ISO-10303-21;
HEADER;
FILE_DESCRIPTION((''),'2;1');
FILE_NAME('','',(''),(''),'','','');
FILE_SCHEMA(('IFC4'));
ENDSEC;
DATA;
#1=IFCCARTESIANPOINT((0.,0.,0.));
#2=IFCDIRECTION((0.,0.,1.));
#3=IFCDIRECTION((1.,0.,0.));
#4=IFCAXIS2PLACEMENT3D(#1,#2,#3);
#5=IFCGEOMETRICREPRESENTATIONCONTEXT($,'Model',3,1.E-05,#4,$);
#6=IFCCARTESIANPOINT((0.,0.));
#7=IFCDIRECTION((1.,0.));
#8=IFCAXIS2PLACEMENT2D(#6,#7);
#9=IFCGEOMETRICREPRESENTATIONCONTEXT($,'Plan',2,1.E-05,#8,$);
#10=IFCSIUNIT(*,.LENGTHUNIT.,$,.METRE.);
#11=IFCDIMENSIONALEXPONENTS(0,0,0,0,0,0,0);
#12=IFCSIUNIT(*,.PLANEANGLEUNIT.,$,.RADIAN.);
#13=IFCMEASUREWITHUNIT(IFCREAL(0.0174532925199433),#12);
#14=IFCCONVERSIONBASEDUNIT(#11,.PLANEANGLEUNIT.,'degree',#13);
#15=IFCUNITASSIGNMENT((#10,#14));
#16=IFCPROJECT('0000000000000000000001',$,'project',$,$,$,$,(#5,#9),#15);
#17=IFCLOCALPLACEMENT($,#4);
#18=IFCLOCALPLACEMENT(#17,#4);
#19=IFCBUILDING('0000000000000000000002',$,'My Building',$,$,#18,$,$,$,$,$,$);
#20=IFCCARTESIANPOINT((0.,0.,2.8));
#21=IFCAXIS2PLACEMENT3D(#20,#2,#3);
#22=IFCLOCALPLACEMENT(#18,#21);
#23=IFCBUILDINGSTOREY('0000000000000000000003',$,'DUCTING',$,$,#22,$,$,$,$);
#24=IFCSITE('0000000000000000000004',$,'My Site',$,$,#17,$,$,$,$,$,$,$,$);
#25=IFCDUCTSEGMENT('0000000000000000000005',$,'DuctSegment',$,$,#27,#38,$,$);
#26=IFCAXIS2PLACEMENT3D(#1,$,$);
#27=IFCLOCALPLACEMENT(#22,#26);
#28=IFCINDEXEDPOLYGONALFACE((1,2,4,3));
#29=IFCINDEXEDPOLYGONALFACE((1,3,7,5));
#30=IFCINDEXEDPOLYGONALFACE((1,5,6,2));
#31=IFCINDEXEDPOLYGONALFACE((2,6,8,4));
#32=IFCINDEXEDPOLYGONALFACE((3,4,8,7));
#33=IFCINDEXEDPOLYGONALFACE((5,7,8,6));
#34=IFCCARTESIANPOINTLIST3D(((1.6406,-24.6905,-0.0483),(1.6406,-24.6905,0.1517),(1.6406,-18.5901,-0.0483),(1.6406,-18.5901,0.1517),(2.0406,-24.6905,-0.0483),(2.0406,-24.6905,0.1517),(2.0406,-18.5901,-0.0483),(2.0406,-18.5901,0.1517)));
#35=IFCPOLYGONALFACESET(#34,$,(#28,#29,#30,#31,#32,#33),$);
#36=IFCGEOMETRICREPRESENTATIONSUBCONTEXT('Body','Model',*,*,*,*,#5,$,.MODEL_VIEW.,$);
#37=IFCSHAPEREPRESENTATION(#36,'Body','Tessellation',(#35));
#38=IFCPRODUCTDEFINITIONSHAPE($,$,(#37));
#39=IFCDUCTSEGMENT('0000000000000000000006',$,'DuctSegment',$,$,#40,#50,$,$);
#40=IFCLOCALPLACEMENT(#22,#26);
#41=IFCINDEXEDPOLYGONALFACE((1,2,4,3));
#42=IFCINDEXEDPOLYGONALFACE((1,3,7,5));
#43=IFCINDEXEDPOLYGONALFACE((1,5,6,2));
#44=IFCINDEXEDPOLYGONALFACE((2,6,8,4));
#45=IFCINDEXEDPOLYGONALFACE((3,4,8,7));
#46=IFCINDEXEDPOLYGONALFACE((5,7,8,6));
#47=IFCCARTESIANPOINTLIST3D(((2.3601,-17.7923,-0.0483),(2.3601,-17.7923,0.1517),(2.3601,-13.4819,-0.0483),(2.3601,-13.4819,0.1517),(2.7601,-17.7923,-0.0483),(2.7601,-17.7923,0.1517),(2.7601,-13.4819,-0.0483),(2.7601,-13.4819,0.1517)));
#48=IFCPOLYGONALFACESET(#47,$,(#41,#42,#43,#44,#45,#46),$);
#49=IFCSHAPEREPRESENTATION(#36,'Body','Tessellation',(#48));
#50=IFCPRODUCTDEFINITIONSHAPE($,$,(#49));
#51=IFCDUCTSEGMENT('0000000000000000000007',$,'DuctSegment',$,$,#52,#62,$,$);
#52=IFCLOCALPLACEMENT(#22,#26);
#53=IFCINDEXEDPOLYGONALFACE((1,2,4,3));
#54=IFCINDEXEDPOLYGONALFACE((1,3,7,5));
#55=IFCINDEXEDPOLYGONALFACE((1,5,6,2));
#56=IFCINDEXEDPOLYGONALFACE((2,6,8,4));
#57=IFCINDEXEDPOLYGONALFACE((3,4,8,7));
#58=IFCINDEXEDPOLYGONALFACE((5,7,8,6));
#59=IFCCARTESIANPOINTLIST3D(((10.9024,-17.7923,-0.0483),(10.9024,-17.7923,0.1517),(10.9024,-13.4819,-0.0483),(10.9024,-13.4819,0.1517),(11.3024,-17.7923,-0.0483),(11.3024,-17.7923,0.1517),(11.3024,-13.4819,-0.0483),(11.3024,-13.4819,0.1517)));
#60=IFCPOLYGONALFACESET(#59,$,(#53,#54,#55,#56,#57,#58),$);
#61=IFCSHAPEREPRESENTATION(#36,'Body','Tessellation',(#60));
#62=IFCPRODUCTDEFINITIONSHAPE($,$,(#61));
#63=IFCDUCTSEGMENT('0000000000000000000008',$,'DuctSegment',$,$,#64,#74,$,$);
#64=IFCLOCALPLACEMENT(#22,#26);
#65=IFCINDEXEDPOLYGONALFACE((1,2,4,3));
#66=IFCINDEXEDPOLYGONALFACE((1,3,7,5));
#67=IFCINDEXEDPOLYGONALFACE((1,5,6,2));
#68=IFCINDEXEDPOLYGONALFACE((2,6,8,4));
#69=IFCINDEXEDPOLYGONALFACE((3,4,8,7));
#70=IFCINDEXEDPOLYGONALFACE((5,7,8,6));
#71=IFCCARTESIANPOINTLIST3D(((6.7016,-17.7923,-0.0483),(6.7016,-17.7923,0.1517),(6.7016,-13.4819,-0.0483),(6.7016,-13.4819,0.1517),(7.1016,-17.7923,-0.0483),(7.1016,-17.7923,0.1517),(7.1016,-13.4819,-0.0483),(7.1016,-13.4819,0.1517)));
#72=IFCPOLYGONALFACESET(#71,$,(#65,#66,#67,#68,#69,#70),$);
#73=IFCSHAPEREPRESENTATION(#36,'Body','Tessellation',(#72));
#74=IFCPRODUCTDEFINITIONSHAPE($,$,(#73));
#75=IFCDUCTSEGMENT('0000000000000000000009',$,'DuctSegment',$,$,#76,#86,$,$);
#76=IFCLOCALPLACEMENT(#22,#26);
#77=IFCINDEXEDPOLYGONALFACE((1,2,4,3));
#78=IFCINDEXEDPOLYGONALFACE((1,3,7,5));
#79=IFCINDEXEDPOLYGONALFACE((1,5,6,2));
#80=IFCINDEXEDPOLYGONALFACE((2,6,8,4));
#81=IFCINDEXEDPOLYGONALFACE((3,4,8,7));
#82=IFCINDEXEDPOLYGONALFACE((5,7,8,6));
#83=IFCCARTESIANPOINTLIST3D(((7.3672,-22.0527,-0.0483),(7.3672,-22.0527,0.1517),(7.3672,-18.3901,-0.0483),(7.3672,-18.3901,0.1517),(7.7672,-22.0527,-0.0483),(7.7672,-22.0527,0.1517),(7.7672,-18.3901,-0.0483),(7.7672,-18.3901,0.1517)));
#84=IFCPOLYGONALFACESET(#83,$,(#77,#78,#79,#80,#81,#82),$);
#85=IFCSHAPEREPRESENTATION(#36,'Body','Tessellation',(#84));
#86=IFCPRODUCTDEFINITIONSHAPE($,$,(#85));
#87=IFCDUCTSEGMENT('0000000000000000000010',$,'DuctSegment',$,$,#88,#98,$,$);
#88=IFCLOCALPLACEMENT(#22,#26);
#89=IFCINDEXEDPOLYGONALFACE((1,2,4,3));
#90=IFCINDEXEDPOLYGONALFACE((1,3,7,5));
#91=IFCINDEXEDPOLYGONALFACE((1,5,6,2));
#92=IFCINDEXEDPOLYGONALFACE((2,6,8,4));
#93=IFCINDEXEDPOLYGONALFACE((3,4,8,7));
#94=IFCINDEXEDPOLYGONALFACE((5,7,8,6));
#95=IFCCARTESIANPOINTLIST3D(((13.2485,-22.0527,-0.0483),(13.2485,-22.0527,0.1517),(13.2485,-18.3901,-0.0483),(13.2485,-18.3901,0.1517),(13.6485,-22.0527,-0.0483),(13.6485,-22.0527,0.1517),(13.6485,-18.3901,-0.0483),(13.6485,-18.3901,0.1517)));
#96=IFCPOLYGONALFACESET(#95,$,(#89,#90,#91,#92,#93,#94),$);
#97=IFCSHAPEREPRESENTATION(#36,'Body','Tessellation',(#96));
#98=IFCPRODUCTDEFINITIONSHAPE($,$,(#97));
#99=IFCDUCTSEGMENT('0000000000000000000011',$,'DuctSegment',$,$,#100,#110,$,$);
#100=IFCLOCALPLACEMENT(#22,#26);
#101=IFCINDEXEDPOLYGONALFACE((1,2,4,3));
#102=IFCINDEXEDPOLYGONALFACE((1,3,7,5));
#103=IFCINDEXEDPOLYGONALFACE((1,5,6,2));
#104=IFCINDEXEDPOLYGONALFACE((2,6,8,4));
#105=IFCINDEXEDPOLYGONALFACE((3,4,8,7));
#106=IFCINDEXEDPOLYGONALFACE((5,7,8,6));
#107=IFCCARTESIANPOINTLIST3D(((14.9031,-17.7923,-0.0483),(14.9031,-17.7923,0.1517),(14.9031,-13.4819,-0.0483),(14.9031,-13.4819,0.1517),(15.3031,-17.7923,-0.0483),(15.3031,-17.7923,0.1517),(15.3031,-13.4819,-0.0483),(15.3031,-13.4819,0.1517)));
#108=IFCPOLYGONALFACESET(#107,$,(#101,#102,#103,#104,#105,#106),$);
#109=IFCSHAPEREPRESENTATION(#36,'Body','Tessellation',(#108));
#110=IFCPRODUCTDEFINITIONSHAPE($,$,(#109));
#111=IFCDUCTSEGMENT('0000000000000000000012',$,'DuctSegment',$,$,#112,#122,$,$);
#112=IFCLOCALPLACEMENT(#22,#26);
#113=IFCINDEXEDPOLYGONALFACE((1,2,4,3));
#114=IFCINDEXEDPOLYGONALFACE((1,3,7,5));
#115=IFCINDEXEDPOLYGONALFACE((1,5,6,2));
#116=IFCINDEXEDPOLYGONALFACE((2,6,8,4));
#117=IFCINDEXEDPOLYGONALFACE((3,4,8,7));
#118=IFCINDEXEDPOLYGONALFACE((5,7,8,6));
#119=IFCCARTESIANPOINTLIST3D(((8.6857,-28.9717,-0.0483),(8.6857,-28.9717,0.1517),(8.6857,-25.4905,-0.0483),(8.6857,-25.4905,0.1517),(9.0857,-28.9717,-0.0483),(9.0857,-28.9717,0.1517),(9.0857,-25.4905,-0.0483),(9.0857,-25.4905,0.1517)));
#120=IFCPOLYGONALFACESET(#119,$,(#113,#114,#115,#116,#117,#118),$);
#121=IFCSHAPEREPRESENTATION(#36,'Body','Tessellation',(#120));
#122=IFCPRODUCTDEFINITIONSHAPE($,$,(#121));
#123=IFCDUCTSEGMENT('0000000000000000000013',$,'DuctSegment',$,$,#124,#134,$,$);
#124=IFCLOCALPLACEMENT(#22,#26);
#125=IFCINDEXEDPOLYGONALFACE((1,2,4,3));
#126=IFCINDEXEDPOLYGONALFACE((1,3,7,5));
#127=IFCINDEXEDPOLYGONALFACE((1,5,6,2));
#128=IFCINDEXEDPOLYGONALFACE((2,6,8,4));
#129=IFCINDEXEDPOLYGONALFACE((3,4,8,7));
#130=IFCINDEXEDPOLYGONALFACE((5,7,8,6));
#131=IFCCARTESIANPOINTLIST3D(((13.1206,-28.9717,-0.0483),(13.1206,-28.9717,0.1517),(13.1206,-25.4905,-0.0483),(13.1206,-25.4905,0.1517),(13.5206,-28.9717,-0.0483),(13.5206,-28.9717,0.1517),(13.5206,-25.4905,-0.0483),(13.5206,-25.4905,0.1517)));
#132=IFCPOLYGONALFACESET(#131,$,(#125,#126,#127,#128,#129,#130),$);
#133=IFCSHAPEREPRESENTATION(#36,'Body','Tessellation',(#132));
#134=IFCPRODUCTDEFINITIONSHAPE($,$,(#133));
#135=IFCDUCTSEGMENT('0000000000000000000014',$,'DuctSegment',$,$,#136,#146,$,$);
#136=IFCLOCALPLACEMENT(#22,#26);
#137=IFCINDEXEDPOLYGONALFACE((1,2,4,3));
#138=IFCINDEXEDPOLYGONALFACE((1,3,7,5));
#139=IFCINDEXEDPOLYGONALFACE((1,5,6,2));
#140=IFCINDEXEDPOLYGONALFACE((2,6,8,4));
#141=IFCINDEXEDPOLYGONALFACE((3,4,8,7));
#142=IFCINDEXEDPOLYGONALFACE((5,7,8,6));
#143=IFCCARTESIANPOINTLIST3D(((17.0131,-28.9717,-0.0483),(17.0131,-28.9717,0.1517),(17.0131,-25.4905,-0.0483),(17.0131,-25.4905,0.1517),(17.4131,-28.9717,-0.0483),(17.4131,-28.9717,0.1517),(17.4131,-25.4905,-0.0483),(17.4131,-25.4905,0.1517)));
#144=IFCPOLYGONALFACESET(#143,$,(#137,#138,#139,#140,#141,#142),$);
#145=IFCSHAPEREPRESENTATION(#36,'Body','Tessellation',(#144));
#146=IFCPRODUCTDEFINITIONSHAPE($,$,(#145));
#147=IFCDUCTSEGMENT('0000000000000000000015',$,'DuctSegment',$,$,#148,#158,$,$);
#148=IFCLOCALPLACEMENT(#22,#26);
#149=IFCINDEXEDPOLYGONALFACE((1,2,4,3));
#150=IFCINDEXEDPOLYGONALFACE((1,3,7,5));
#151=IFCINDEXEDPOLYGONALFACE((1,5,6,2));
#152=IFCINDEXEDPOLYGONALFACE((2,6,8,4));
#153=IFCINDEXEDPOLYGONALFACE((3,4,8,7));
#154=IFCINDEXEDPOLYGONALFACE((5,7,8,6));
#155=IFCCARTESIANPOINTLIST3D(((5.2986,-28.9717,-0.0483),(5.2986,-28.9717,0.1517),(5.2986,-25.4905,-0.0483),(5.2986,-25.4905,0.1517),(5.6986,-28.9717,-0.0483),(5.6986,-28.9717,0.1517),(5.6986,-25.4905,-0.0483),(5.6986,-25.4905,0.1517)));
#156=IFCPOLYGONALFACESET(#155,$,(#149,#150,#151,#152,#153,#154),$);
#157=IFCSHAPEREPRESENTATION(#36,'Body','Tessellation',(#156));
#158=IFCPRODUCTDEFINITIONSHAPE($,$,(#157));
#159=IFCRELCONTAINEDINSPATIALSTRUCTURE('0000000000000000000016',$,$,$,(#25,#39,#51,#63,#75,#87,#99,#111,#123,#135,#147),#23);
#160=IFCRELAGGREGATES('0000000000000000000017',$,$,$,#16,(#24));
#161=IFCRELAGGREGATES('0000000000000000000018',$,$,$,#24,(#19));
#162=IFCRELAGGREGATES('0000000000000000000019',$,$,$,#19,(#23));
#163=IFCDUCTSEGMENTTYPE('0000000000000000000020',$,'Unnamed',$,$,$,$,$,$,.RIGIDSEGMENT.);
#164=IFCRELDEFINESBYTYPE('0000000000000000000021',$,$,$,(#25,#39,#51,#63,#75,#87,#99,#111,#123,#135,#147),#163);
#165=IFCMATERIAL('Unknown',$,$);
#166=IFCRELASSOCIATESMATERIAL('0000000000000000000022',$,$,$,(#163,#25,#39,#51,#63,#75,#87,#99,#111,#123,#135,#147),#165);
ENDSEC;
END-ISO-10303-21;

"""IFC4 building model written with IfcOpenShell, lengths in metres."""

from ifc_helpers import new_model, entity, si_unit, converted_unit, frame, origin_with_axes, origin_2d_with_axis, place, context, subcontext, project, spatial, rectangle, extrude, material, material_profile, profile_set, profile_usage, type_object, element, save


model = new_model("IFC4")

# Units and contexts
model_context = context("Model", 3, precision=1e-05, world=origin_with_axes())
plan_context = context("Plan", 2, precision=1e-05, world=origin_2d_with_axis())
body_context = subcontext(model_context, "Body", "Model", "MODEL_VIEW")
ifc_project = project(units=[si_unit("LENGTHUNIT", "METRE"), converted_unit("PLANEANGLEUNIT", "degree", entity("IfcReal", 0.0174532925199433), si_unit("PLANEANGLEUNIT", "RADIAN"), dimensions=[0, 0, 0, 0, 0, 0, 0])], contexts=[model_context, plan_context])

# Site, building, storey
site_placement = place(None, origin_with_axes())
site = spatial("IfcSite", under=ifc_project, at=site_placement, Name="My Site")
building_placement = place(site_placement, origin_with_axes())
building = spatial("IfcBuilding", under=site, at=building_placement, Name="My Building")
storey_placement = place(building_placement, frame((0.0, 0.0, 2.8), z_axis=(0.0, 0.0, 1.0), x_axis=(1.0, 0.0, 0.0)))
storey = spatial("IfcBuildingStorey", under=building, at=storey_placement, Name="DUCTING")

# Duct segments
ifc_material = material(Name="Unknown")
ifc_material_profile_1 = material_profile(ifc_material, rectangle(XDim=0.4, YDim=0.2))
ifc_profile_set_1 = profile_set([ifc_material_profile_1])
ifc_profile_usage_1 = profile_usage(ifc_profile_set_1, cardinal=5)
duct_segment_type = type_object("IfcDuctSegmentType", Name="Unnamed", PredefinedType="RIGIDSEGMENT", material=ifc_profile_set_1)
duct_segment_1_placement = place(storey_placement, frame((1.8406, -18.5901, 0.0517), z_axis=(0.0, -1.0, 0.0), x_axis=(1.0, 0.0, 0.0)))
element("IfcDuctSegment", 1, at=duct_segment_1_placement, inside=storey, type_object=duct_segment_type, material=ifc_profile_usage_1, Name="DuctSegment", context=body_context, shape_type="SweptSolid", body=[
    extrude(rectangle(XDim=0.4, YDim=0.2), origin_with_axes(), (0.0, 0.0, 1.0), 6.1004),
])
ifc_profile_usage_2 = profile_usage(ifc_profile_set_1, cardinal=5)
duct_segment_2_placement = place(storey_placement, frame((2.5601, -13.4819, 0.0517), z_axis=(0.0, -1.0, 0.0), x_axis=(1.0, 0.0, 0.0)))
element("IfcDuctSegment", 2, at=duct_segment_2_placement, inside=storey, type_object=duct_segment_type, material=ifc_profile_usage_2, Name="DuctSegment", context=body_context, shape_type="SweptSolid", body=[
    extrude(rectangle(XDim=0.4, YDim=0.2), origin_with_axes(), (0.0, 0.0, 1.0), 4.3103),
])
ifc_profile_usage_3 = profile_usage(ifc_profile_set_1, cardinal=5)
duct_segment_3_placement = place(storey_placement, frame((11.1024, -13.4819, 0.0517), z_axis=(0.0, -1.0, 0.0), x_axis=(1.0, 0.0, 0.0)))
element("IfcDuctSegment", 3, at=duct_segment_3_placement, inside=storey, type_object=duct_segment_type, material=ifc_profile_usage_3, Name="DuctSegment", context=body_context, shape_type="SweptSolid", body=[
    extrude(rectangle(XDim=0.4, YDim=0.2), origin_with_axes(), (0.0, 0.0, 1.0), 4.3103),
])
ifc_profile_usage_4 = profile_usage(ifc_profile_set_1, cardinal=5)
duct_segment_4_placement = place(storey_placement, frame((6.9016, -13.4819, 0.0517), z_axis=(0.0, -1.0, 0.0), x_axis=(1.0, 0.0, 0.0)))
element("IfcDuctSegment", 4, at=duct_segment_4_placement, inside=storey, type_object=duct_segment_type, material=ifc_profile_usage_4, Name="DuctSegment", context=body_context, shape_type="SweptSolid", body=[
    extrude(rectangle(XDim=0.4, YDim=0.2), origin_with_axes(), (0.0, 0.0, 1.0), 4.3103),
])
ifc_profile_usage_5 = profile_usage(ifc_profile_set_1, cardinal=5)
duct_segment_5_placement = place(storey_placement, frame((7.5672, -22.0527, 0.0517), z_axis=(0.0, 1.0, 0.0), x_axis=(-1.0, 0.0, 0.0)))
element("IfcDuctSegment", 5, at=duct_segment_5_placement, inside=storey, type_object=duct_segment_type, material=ifc_profile_usage_5, Name="DuctSegment", context=body_context, shape_type="SweptSolid", body=[
    extrude(rectangle(XDim=0.4, YDim=0.2), origin_with_axes(), (0.0, 0.0, 1.0), 3.6626),
])
ifc_profile_usage_6 = profile_usage(ifc_profile_set_1, cardinal=5)
duct_segment_6_placement = place(storey_placement, frame((13.4485, -22.0527, 0.0517), z_axis=(0.0, 1.0, 0.0), x_axis=(-1.0, 0.0, 0.0)))
element("IfcDuctSegment", 6, at=duct_segment_6_placement, inside=storey, type_object=duct_segment_type, material=ifc_profile_usage_6, Name="DuctSegment", context=body_context, shape_type="SweptSolid", body=[
    extrude(rectangle(XDim=0.4, YDim=0.2), origin_with_axes(), (0.0, 0.0, 1.0), 3.6626),
])
ifc_profile_usage_7 = profile_usage(ifc_profile_set_1, cardinal=5)
duct_segment_7_placement = place(storey_placement, frame((15.1031, -13.4819, 0.0517), z_axis=(0.0, -1.0, 0.0), x_axis=(1.0, 0.0, 0.0)))
element("IfcDuctSegment", 7, at=duct_segment_7_placement, inside=storey, type_object=duct_segment_type, material=ifc_profile_usage_7, Name="DuctSegment", context=body_context, shape_type="SweptSolid", body=[
    extrude(rectangle(XDim=0.4, YDim=0.2), origin_with_axes(), (0.0, 0.0, 1.0), 4.3103),
])
ifc_profile_usage_8 = profile_usage(ifc_profile_set_1, cardinal=5)
duct_segment_8_placement = place(storey_placement, frame((8.8857, -28.9717, 0.0517), z_axis=(0.0, 1.0, 0.0), x_axis=(-1.0, 0.0, 0.0)))
element("IfcDuctSegment", 8, at=duct_segment_8_placement, inside=storey, type_object=duct_segment_type, material=ifc_profile_usage_8, Name="DuctSegment", context=body_context, shape_type="SweptSolid", body=[
    extrude(rectangle(XDim=0.4, YDim=0.2), origin_with_axes(), (0.0, 0.0, 1.0), 3.4812),
])
ifc_profile_usage_9 = profile_usage(ifc_profile_set_1, cardinal=5)
duct_segment_9_placement = place(storey_placement, frame((13.3206, -28.9717, 0.0517), z_axis=(0.0, 1.0, 0.0), x_axis=(-1.0, 0.0, 0.0)))
element("IfcDuctSegment", 9, at=duct_segment_9_placement, inside=storey, type_object=duct_segment_type, material=ifc_profile_usage_9, Name="DuctSegment", context=body_context, shape_type="SweptSolid", body=[
    extrude(rectangle(XDim=0.4, YDim=0.2), origin_with_axes(), (0.0, 0.0, 1.0), 3.4812),
])
ifc_profile_usage_10 = profile_usage(ifc_profile_set_1, cardinal=5)
duct_segment_10_placement = place(storey_placement, frame((17.2131, -28.9717, 0.0517), z_axis=(0.0, 1.0, 0.0), x_axis=(-1.0, 0.0, 0.0)))
element("IfcDuctSegment", 10, at=duct_segment_10_placement, inside=storey, type_object=duct_segment_type, material=ifc_profile_usage_10, Name="DuctSegment", context=body_context, shape_type="SweptSolid", body=[
    extrude(rectangle(XDim=0.4, YDim=0.2), origin_with_axes(), (0.0, 0.0, 1.0), 3.4812),
])
ifc_profile_usage_11 = profile_usage(ifc_profile_set_1, cardinal=5)
duct_segment_11_placement = place(storey_placement, frame((5.4986, -28.9717, 0.0517), z_axis=(0.0, 1.0, 0.0), x_axis=(-1.0, 0.0, 0.0)))
element("IfcDuctSegment", 11, at=duct_segment_11_placement, inside=storey, type_object=duct_segment_type, material=ifc_profile_usage_11, Name="DuctSegment", context=body_context, shape_type="SweptSolid", body=[
    extrude(rectangle(XDim=0.4, YDim=0.2), origin_with_axes(), (0.0, 0.0, 1.0), 3.4812),
])

save(model, "model.ifc")
